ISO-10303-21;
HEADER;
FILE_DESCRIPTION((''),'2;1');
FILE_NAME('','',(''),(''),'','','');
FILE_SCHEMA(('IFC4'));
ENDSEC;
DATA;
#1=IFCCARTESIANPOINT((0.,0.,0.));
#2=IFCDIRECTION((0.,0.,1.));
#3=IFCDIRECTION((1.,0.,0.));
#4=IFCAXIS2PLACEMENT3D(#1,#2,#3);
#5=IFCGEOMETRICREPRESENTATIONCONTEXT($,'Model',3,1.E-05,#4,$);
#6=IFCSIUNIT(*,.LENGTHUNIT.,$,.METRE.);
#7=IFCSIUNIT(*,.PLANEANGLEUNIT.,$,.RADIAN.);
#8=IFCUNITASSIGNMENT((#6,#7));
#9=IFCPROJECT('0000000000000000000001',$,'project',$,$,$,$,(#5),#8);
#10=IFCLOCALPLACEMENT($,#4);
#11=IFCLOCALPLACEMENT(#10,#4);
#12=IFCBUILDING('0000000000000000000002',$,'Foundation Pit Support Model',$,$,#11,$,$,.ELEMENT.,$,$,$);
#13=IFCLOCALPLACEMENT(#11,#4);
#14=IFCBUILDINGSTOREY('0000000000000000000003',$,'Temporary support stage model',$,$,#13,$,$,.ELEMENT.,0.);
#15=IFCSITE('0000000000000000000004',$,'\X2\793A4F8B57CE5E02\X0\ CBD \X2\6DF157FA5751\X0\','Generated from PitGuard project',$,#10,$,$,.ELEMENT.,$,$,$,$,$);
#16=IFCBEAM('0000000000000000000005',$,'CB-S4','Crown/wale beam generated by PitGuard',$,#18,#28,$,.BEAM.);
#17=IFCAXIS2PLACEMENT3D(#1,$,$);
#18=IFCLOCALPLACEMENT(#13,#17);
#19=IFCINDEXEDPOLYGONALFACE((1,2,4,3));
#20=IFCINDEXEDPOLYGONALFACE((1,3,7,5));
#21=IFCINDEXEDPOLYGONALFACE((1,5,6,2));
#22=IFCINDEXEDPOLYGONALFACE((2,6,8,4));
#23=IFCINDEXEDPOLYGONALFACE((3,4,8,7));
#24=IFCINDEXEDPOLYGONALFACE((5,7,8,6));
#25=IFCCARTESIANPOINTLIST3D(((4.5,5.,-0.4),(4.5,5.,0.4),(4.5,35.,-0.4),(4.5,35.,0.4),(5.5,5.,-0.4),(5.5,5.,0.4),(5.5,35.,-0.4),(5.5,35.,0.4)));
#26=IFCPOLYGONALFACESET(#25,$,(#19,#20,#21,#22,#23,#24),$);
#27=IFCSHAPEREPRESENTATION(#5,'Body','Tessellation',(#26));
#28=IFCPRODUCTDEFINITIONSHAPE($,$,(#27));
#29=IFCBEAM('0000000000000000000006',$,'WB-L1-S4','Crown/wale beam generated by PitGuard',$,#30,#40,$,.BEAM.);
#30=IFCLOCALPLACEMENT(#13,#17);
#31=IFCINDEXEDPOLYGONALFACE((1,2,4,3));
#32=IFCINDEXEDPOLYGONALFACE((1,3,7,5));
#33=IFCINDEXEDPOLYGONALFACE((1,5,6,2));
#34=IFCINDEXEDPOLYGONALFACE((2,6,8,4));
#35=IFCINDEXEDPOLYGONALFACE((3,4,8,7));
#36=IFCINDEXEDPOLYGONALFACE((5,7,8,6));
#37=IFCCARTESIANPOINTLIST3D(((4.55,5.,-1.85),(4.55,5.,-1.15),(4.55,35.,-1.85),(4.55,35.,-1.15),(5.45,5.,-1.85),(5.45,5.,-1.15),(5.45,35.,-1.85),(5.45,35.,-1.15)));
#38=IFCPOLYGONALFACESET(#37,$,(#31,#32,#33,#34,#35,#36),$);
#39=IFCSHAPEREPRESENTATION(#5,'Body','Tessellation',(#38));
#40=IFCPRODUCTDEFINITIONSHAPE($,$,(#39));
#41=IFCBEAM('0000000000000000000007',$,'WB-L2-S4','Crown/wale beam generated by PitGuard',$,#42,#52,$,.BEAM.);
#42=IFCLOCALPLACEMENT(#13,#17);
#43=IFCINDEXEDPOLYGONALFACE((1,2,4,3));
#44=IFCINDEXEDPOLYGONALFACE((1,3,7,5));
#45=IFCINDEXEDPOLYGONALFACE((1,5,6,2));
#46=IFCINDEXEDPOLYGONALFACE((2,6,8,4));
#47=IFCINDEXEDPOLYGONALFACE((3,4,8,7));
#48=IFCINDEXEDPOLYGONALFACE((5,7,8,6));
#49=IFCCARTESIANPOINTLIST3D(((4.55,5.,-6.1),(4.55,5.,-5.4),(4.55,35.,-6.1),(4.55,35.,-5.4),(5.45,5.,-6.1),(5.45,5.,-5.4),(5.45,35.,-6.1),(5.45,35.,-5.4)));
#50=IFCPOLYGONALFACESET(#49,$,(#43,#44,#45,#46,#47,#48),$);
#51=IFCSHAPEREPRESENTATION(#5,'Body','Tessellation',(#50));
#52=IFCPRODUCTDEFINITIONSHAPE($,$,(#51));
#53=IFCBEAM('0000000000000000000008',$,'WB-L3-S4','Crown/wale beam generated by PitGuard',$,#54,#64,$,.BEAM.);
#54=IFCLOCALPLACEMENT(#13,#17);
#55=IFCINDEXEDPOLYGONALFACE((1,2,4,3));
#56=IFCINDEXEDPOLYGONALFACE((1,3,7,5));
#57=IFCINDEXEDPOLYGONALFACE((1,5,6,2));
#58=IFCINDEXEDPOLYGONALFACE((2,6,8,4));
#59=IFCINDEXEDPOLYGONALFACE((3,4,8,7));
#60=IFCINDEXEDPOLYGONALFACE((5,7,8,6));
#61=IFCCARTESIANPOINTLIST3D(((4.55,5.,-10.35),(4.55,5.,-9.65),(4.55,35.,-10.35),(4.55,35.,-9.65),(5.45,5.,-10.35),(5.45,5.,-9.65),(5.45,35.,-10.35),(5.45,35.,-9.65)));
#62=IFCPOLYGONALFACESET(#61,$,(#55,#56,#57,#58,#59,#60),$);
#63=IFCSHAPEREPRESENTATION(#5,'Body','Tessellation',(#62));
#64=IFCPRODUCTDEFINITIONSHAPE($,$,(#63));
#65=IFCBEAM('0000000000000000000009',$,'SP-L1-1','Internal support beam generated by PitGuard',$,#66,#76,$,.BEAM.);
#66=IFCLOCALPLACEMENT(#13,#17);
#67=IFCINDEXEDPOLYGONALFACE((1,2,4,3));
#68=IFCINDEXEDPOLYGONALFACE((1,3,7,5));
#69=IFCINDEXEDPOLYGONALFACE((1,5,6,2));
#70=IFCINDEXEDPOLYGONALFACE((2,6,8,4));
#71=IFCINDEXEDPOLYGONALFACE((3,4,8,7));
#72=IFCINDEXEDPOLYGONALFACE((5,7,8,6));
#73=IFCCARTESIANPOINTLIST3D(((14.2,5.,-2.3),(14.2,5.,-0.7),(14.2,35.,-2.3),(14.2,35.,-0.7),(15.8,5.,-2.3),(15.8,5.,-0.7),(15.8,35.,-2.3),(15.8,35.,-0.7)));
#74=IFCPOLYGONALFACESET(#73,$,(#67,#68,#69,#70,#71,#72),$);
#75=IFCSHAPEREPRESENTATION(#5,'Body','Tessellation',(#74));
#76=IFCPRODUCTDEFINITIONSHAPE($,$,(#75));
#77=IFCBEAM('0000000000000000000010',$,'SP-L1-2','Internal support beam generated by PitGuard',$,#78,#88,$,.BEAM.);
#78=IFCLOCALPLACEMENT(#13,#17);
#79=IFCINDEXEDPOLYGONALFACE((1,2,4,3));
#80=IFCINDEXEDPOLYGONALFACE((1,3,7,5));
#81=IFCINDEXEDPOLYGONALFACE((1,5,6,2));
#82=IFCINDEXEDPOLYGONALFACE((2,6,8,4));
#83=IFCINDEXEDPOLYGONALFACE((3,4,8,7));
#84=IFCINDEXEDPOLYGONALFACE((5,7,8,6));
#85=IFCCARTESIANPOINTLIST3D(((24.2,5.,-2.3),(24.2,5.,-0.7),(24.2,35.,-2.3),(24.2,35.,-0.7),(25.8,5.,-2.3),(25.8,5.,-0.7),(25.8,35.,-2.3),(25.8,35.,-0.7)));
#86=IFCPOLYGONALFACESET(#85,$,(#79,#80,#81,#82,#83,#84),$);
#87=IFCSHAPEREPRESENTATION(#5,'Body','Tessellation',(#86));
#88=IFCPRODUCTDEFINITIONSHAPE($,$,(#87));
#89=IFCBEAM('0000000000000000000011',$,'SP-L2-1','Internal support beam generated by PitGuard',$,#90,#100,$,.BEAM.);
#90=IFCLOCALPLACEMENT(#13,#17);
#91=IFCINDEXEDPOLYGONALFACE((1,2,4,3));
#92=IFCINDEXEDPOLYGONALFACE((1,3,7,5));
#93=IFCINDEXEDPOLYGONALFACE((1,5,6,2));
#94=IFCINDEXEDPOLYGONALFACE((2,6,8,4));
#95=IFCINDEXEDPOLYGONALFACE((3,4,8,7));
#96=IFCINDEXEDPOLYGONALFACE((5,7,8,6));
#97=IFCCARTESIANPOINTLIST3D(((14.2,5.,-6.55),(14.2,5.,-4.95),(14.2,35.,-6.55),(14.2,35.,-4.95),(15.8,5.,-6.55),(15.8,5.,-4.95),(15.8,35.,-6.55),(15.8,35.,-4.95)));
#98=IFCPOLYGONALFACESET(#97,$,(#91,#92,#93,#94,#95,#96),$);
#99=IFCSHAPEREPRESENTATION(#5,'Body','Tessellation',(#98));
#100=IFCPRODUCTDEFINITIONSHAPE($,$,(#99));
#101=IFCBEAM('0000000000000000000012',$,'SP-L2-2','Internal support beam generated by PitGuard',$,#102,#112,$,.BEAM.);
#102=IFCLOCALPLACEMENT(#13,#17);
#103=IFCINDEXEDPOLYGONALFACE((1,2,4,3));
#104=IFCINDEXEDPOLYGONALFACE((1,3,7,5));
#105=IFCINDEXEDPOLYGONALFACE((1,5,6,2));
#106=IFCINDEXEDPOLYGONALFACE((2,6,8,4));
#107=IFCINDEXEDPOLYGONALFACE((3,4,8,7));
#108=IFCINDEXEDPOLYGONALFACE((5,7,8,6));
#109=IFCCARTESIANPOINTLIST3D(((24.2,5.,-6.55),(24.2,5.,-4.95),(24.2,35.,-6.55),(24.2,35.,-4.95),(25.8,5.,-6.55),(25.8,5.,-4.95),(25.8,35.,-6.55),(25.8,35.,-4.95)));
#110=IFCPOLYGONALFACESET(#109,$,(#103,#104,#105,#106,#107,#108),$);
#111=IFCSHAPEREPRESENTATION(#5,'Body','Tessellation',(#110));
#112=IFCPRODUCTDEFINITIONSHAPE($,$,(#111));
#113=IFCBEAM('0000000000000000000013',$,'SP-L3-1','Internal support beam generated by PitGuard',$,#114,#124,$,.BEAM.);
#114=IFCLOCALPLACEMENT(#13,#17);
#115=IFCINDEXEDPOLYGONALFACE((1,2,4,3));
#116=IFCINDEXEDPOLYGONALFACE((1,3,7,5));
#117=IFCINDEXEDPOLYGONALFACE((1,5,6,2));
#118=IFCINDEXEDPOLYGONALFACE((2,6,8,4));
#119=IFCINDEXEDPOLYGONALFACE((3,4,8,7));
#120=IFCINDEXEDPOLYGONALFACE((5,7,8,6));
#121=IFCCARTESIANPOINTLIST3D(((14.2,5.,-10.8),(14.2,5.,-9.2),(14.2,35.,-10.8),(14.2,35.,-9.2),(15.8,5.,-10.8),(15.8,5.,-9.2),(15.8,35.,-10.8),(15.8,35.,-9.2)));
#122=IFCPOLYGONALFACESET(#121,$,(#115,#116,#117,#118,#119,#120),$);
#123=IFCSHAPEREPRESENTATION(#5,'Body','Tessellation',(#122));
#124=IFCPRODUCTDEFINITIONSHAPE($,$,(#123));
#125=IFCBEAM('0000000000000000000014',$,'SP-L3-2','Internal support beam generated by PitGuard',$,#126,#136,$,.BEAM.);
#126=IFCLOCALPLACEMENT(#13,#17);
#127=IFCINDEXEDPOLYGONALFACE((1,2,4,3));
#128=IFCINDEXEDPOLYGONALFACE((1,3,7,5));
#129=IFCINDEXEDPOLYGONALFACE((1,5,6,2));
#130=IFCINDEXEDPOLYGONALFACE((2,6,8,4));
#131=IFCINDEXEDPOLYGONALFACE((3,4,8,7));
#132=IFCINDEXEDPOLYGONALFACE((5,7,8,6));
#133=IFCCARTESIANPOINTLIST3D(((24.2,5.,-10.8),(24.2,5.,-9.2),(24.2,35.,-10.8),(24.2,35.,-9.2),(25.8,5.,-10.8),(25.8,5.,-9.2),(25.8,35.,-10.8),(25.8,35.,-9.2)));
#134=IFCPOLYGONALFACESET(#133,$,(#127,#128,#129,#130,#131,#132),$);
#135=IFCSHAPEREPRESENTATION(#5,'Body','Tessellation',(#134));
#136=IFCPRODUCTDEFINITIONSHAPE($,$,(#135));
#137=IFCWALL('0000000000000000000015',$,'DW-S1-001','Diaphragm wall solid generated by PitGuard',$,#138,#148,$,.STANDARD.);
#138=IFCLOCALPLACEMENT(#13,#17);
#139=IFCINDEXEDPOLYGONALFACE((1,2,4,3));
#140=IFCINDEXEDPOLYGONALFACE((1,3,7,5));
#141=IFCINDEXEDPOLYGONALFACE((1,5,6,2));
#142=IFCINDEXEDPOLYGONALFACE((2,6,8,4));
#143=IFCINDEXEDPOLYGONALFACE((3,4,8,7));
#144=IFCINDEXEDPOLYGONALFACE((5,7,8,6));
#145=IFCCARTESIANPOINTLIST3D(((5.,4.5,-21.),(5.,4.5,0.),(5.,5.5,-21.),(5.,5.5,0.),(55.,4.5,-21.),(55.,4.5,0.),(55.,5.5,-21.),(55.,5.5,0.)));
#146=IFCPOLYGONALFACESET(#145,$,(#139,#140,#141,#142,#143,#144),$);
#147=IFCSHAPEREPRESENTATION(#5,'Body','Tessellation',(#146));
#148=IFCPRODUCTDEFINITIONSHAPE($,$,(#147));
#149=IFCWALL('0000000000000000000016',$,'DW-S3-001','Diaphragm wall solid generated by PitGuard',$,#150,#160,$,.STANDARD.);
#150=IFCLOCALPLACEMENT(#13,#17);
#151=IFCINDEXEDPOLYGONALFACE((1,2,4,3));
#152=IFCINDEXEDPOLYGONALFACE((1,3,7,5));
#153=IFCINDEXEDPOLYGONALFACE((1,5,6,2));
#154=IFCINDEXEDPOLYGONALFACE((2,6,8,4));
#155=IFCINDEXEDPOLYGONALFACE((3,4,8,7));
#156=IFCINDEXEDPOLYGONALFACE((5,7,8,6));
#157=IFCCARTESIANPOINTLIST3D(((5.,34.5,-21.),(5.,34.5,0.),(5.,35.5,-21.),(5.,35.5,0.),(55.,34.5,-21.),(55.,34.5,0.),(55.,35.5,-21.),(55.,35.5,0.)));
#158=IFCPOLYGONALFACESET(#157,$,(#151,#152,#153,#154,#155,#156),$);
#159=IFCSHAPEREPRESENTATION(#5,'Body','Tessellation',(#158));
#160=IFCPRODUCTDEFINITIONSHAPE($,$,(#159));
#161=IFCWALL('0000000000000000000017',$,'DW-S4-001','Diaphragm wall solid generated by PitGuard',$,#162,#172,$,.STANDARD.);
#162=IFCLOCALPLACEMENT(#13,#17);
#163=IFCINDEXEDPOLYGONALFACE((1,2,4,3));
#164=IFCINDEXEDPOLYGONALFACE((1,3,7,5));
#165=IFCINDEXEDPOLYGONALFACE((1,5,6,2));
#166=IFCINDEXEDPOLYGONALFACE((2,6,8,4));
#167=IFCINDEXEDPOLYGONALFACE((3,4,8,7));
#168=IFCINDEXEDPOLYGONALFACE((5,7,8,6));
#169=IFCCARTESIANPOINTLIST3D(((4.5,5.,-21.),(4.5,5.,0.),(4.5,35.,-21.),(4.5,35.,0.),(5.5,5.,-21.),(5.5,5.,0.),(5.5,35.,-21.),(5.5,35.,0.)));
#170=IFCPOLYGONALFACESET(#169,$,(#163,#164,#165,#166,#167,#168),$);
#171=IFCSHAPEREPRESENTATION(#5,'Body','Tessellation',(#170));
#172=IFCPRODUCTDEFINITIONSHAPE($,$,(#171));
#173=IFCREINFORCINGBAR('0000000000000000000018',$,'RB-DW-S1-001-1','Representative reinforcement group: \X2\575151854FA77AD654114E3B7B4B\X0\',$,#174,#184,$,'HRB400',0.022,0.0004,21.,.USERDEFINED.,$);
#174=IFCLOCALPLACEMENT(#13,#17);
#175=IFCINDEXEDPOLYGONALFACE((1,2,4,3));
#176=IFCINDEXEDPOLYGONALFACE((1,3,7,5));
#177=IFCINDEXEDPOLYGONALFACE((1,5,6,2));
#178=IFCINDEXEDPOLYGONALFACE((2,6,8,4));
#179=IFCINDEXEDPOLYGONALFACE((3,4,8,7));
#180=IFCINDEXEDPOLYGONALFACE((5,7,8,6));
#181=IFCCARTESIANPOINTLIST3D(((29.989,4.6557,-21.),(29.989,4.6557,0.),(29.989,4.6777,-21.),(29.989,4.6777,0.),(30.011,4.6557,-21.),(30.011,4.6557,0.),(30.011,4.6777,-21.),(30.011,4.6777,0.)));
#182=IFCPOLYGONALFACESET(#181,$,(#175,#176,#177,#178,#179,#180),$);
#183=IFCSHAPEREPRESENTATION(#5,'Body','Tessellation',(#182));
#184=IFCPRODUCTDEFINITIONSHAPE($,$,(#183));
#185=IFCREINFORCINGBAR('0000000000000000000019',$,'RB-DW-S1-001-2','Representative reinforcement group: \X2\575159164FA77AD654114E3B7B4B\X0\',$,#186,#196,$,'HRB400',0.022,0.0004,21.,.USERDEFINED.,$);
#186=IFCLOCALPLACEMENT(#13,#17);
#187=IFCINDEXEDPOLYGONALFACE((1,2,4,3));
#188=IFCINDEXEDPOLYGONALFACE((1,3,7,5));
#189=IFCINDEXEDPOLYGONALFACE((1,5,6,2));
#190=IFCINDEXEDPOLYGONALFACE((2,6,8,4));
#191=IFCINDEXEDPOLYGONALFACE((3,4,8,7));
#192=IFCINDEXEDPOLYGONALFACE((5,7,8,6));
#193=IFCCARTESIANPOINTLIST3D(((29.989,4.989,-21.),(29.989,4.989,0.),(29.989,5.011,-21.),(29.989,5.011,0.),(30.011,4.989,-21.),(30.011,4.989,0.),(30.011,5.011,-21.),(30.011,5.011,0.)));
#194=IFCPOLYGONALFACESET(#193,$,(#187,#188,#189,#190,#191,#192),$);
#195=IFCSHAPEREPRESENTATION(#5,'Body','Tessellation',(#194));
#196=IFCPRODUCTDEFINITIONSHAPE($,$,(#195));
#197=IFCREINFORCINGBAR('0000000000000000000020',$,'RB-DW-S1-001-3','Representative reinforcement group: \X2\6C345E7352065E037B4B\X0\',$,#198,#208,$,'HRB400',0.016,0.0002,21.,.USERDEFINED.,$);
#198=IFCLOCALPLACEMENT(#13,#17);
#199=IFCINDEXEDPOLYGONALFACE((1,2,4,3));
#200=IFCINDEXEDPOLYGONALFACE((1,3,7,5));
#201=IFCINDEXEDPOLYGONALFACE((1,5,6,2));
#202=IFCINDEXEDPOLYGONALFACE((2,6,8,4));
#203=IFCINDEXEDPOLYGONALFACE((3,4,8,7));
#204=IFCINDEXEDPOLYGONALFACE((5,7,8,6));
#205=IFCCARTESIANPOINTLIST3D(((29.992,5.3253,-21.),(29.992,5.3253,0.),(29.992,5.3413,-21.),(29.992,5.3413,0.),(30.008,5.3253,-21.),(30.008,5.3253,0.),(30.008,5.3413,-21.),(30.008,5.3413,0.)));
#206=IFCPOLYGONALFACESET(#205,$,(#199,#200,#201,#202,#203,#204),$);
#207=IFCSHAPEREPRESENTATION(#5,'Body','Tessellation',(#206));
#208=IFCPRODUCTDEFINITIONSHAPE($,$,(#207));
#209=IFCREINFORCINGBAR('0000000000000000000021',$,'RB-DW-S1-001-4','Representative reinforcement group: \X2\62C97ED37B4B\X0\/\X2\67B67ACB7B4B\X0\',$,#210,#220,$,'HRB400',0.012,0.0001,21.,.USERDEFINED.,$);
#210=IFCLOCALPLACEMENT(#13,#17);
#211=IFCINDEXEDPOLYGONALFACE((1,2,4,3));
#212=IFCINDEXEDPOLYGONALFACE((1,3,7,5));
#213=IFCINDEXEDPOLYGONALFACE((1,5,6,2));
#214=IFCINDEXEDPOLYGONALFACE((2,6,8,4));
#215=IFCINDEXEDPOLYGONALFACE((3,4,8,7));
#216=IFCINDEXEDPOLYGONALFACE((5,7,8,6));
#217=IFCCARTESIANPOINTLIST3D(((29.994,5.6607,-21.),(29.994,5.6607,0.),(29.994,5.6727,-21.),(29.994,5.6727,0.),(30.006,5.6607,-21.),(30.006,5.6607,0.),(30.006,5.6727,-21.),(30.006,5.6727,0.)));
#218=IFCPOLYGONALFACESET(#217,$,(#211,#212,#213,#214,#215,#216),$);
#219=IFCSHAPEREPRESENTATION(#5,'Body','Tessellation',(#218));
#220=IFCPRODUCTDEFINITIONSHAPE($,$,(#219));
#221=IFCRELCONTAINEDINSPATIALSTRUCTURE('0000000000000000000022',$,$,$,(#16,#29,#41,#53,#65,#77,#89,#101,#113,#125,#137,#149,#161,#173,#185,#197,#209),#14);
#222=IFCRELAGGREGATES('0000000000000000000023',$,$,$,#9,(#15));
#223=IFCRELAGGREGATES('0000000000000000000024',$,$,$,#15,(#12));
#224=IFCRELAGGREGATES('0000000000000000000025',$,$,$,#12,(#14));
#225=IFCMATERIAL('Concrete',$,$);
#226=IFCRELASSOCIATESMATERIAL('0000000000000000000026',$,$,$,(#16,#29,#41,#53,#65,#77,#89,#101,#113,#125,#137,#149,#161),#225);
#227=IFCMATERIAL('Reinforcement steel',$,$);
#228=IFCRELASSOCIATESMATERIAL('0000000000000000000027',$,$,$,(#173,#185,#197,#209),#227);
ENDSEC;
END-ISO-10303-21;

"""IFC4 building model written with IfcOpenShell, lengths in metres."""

from ifc_helpers import new_model, si_unit, frame, origin_with_axes, origin_2d, place, context, project, spatial, rectangle, extrude, material, element, save


model = new_model("IFC4")

# Units and contexts
model_context = context("Model", 3, precision=1e-05, world=origin_with_axes())
ifc_project = project(units=[si_unit("LENGTHUNIT", "METRE"), si_unit("PLANEANGLEUNIT", "RADIAN")], contexts=[model_context])

# Site, building, storey
site_placement = place(None, origin_with_axes())
site = spatial("IfcSite", under=ifc_project, at=site_placement, Name="示例城市 CBD 深基坑", Description="Generated from PitGuard project", CompositionType="ELEMENT")
building_placement = place(site_placement, origin_with_axes())
building = spatial("IfcBuilding", under=site, at=building_placement, Name="Foundation Pit Support Model", CompositionType="ELEMENT")
storey_placement = place(building_placement, origin_with_axes())
storey = spatial("IfcBuildingStorey", under=building, at=storey_placement, Name="Temporary support stage model", CompositionType="ELEMENT", Elevation=0.0)

# Beams
ifc_material_1 = material(Name="Concrete")
beam_placement = place(storey_placement, frame((5.0, 20.0, -0.4), z_axis=(0.0, 0.0, 1.0), x_axis=(0.0, -1.0, 0.0)))
element("IfcBeam", 1, at=beam_placement, inside=storey, material=ifc_material_1, Name="CB-S4", Description="Crown/wale beam generated by PitGuard", PredefinedType="BEAM", context=model_context, shape_type="SweptSolid", body=[
    extrude(rectangle(XDim=30.0, YDim=1.0, at=origin_2d()), origin_with_axes(), (0.0, 0.0, 1.0), 0.8),
])
for number, where, z_axis, x_axis, name in (
    (2, (5.0, 20.0, -1.85), (0.0, 0.0, 1.0), (0.0, -1.0, 0.0), "WB-L1-S4"),
    (3, (5.0, 20.0, -6.1), (0.0, 0.0, 1.0), (0.0, -1.0, 0.0), "WB-L2-S4"),
    (4, (5.0, 20.0, -10.35), (0.0, 0.0, 1.0), (0.0, -1.0, 0.0), "WB-L3-S4"),
):
    element("IfcBeam", number, at=place(storey_placement, frame(where, z_axis=z_axis, x_axis=x_axis)), inside=storey, material=ifc_material_1, Name=name, Description="Crown/wale beam generated by PitGuard", PredefinedType="BEAM", context=model_context, shape_type="SweptSolid", body=[
        extrude(rectangle(XDim=30.0, YDim=0.9, at=origin_2d()), origin_with_axes(), (0.0, 0.0, 1.0), 0.7),
    ])
for number, where, z_axis, x_axis, name in (
    (5, (15.0, 20.0, -2.3), (0.0, 0.0, 1.0), (0.0, 1.0, 0.0), "SP-L1-1"),
    (6, (25.0, 20.0, -2.3), (0.0, 0.0, 1.0), (0.0, 1.0, 0.0), "SP-L1-2"),
    (7, (15.0, 20.0, -6.55), (0.0, 0.0, 1.0), (0.0, 1.0, 0.0), "SP-L2-1"),
    (8, (25.0, 20.0, -6.55), (0.0, 0.0, 1.0), (0.0, 1.0, 0.0), "SP-L2-2"),
    (9, (15.0, 20.0, -10.8), (0.0, 0.0, 1.0), (0.0, 1.0, 0.0), "SP-L3-1"),
    (10, (25.0, 20.0, -10.8), (0.0, 0.0, 1.0), (0.0, 1.0, 0.0), "SP-L3-2"),
):
    element("IfcBeam", number, at=place(storey_placement, frame(where, z_axis=z_axis, x_axis=x_axis)), inside=storey, material=ifc_material_1, Name=name, Description="Internal support beam generated by PitGuard", PredefinedType="BEAM", context=model_context, shape_type="SweptSolid", body=[
        extrude(rectangle(XDim=30.0, YDim=1.6, at=origin_2d()), origin_with_axes(), (0.0, 0.0, 1.0), 1.6),
    ])

# Walls
for number, where, z_axis, x_axis, name in (
    (11, (30.0, 5.0, -21.0), (0.0, 0.0, 1.0), (1.0, 0.0, 0.0), "DW-S1-001"),
    (12, (30.0, 35.0, -21.0), (0.0, 0.0, 1.0), (-1.0, 0.0, 0.0), "DW-S3-001"),
):
    element("IfcWall", number, at=place(storey_placement, frame(where, z_axis=z_axis, x_axis=x_axis)), inside=storey, material=ifc_material_1, Name=name, Description="Diaphragm wall solid generated by PitGuard", PredefinedType="STANDARD", context=model_context, shape_type="SweptSolid", body=[
        extrude(rectangle(XDim=50.0, YDim=1.0, at=origin_2d()), origin_with_axes(), (0.0, 0.0, 1.0), 21.0),
    ])
wall_placement = place(storey_placement, frame((5.0, 20.0, -21.0), z_axis=(0.0, 0.0, 1.0), x_axis=(0.0, -1.0, 0.0)))
element("IfcWall", 13, at=wall_placement, inside=storey, material=ifc_material_1, Name="DW-S4-001", Description="Diaphragm wall solid generated by PitGuard", PredefinedType="STANDARD", context=model_context, shape_type="SweptSolid", body=[
    extrude(rectangle(XDim=30.0, YDim=1.0, at=origin_2d()), origin_with_axes(), (0.0, 0.0, 1.0), 21.0),
])

# Reinforcing bars
ifc_material_2 = material(Name="Reinforcement steel")
for number, where, z_axis, x_axis, name, description in (
    (14, (30.0, 4.6667, -21.0), (0.0, 0.0, 1.0), (1.0, 0.0, 0.0), "RB-DW-S1-001-1", "Representative reinforcement group: 坑内侧竖向主筋"),
    (15, (30.0, 5.0, -21.0), (0.0, 0.0, 1.0), (1.0, 0.0, 0.0), "RB-DW-S1-001-2", "Representative reinforcement group: 坑外侧竖向主筋"),
):
    element("IfcReinforcingBar", number, at=place(storey_placement, frame(where, z_axis=z_axis, x_axis=x_axis)), inside=storey, material=ifc_material_2, Name=name, Description=description, SteelGrade="HRB400", BarLength=21.0, CrossSectionArea=0.0004, NominalDiameter=0.022, PredefinedType="USERDEFINED", context=model_context, shape_type="SweptSolid", body=[
        extrude(rectangle(XDim=0.022, YDim=0.022, at=origin_2d()), origin_with_axes(), (0.0, 0.0, 1.0), 21.0),
    ])
reinforcing_bar_1_placement = place(storey_placement, frame((30.0, 5.3333, -21.0), z_axis=(0.0, 0.0, 1.0), x_axis=(1.0, 0.0, 0.0)))
element("IfcReinforcingBar", 16, at=reinforcing_bar_1_placement, inside=storey, material=ifc_material_2, Name="RB-DW-S1-001-3", Description="Representative reinforcement group: 水平分布筋", SteelGrade="HRB400", BarLength=21.0, CrossSectionArea=0.0002, NominalDiameter=0.016, PredefinedType="USERDEFINED", context=model_context, shape_type="SweptSolid", body=[
    extrude(rectangle(XDim=0.016, YDim=0.016, at=origin_2d()), origin_with_axes(), (0.0, 0.0, 1.0), 21.0),
])
reinforcing_bar_2_placement = place(storey_placement, frame((30.0, 5.6667, -21.0), z_axis=(0.0, 0.0, 1.0), x_axis=(1.0, 0.0, 0.0)))
element("IfcReinforcingBar", 17, at=reinforcing_bar_2_placement, inside=storey, material=ifc_material_2, Name="RB-DW-S1-001-4", Description="Representative reinforcement group: 拉结筋/架立筋", SteelGrade="HRB400", BarLength=21.0, CrossSectionArea=0.0001, NominalDiameter=0.012, PredefinedType="USERDEFINED", context=model_context, shape_type="SweptSolid", body=[
    extrude(rectangle(XDim=0.012, YDim=0.012, at=origin_2d()), origin_with_axes(), (0.0, 0.0, 1.0), 21.0),
])

save(model, "model.ifc")
